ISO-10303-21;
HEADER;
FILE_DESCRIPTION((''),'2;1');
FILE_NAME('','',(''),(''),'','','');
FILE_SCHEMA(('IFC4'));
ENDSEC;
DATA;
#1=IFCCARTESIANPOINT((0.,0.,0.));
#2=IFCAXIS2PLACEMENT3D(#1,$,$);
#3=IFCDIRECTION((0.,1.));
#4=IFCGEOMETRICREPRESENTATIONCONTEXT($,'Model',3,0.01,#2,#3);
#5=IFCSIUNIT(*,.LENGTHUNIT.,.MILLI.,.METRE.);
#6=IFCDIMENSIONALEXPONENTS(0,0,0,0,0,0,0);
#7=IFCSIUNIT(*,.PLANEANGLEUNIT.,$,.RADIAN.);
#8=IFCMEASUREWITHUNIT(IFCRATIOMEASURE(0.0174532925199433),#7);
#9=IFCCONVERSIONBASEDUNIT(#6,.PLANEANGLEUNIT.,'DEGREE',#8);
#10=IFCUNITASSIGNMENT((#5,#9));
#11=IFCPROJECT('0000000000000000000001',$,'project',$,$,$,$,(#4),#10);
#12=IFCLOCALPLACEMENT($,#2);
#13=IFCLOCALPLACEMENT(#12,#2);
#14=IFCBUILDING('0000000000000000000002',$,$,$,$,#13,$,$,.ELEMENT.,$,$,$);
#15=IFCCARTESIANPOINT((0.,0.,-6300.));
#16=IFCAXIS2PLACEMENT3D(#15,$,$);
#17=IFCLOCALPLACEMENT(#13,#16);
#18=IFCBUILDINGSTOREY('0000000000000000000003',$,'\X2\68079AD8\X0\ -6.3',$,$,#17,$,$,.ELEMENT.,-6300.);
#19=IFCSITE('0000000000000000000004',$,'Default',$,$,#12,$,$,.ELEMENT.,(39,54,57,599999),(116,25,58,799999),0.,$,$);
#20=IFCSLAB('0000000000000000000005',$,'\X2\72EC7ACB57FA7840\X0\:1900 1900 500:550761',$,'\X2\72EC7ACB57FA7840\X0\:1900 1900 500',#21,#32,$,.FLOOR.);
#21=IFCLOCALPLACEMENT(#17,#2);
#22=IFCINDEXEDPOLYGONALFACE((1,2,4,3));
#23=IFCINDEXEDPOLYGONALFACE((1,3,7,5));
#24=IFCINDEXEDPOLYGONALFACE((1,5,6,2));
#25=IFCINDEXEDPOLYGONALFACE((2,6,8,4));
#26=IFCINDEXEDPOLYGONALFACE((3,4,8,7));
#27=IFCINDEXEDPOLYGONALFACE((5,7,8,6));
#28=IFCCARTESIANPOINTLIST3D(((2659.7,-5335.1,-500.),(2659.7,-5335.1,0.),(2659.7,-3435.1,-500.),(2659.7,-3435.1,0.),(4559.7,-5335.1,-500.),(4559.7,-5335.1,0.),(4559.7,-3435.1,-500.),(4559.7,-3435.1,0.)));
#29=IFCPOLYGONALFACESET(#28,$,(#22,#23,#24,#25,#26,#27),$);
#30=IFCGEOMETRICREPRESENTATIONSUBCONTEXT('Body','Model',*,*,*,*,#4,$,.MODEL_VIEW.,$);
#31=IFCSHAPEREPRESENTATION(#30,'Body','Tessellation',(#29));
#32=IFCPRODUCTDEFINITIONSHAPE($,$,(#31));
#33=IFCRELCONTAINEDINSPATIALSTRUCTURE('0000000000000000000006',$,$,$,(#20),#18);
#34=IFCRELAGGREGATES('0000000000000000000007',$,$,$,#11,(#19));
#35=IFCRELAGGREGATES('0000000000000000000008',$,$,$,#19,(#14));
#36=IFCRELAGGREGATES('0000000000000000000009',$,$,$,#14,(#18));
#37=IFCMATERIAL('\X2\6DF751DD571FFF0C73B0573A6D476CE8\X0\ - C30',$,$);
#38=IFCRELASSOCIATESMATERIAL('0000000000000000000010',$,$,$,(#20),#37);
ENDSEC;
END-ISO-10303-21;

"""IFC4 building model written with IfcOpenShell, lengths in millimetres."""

from ifc_helpers import new_model, entity, si_unit, converted_unit, direction, frame, frame_2d, origin, place, context, subcontext, project, spatial, rectangle, extrude, material, element, save


model = new_model("IFC4")

# Units and contexts
model_context = context("Model", 3, precision=0.01, world=origin(), true_north=direction((0.0, 1.0)))
body_context = subcontext(model_context, "Body", "Model", "MODEL_VIEW")
ifc_project = project(units=[si_unit("LENGTHUNIT", "METRE", prefix="MILLI"), converted_unit("PLANEANGLEUNIT", "DEGREE", entity("IfcRatioMeasure", 0.0174532925199433), si_unit("PLANEANGLEUNIT", "RADIAN"), dimensions=[0, 0, 0, 0, 0, 0, 0])], contexts=[model_context])

# Site, building, storey
site_placement = place(None, origin())
site = spatial("IfcSite", under=ifc_project, at=site_placement, Name="Default", CompositionType="ELEMENT", RefLatitude=(39, 54, 57, 599999), RefLongitude=(116, 25, 58, 799999), RefElevation=0.0)
building_placement = place(site_placement, origin())
building = spatial("IfcBuilding", under=site, at=building_placement, CompositionType="ELEMENT")
storey_placement = place(building_placement, frame((0.0, 0.0, -6300.0)))
storey = spatial("IfcBuildingStorey", under=building, at=storey_placement, Name="标高 -6.3", CompositionType="ELEMENT", Elevation=-6300.0)

# Slab
ifc_material = material(Name="混凝土，现场浇注 - C30")
slab_placement = place(storey_placement, frame((2659.7, -5335.1, -500.0)))
element("IfcSlab", 1, at=slab_placement, inside=storey, material=ifc_material, Name="独立基础:1900 1900 500:550761", ObjectType="独立基础:1900 1900 500", PredefinedType="FLOOR", context=body_context, shape_type="SweptSolid", body=[
    extrude(rectangle(XDim=1900.0, YDim=1900.0, at=frame_2d((0.0, 0.0), x_axis=(1.0, 0.0))), frame((950.0, 950.0, 0.0), z_axis=(0.0, 0.0, 1.0), x_axis=(-1.0, 0.0, 0.0)), (0.0, 0.0, 1.0), 500.0),
])

save(model, "model.ifc")
